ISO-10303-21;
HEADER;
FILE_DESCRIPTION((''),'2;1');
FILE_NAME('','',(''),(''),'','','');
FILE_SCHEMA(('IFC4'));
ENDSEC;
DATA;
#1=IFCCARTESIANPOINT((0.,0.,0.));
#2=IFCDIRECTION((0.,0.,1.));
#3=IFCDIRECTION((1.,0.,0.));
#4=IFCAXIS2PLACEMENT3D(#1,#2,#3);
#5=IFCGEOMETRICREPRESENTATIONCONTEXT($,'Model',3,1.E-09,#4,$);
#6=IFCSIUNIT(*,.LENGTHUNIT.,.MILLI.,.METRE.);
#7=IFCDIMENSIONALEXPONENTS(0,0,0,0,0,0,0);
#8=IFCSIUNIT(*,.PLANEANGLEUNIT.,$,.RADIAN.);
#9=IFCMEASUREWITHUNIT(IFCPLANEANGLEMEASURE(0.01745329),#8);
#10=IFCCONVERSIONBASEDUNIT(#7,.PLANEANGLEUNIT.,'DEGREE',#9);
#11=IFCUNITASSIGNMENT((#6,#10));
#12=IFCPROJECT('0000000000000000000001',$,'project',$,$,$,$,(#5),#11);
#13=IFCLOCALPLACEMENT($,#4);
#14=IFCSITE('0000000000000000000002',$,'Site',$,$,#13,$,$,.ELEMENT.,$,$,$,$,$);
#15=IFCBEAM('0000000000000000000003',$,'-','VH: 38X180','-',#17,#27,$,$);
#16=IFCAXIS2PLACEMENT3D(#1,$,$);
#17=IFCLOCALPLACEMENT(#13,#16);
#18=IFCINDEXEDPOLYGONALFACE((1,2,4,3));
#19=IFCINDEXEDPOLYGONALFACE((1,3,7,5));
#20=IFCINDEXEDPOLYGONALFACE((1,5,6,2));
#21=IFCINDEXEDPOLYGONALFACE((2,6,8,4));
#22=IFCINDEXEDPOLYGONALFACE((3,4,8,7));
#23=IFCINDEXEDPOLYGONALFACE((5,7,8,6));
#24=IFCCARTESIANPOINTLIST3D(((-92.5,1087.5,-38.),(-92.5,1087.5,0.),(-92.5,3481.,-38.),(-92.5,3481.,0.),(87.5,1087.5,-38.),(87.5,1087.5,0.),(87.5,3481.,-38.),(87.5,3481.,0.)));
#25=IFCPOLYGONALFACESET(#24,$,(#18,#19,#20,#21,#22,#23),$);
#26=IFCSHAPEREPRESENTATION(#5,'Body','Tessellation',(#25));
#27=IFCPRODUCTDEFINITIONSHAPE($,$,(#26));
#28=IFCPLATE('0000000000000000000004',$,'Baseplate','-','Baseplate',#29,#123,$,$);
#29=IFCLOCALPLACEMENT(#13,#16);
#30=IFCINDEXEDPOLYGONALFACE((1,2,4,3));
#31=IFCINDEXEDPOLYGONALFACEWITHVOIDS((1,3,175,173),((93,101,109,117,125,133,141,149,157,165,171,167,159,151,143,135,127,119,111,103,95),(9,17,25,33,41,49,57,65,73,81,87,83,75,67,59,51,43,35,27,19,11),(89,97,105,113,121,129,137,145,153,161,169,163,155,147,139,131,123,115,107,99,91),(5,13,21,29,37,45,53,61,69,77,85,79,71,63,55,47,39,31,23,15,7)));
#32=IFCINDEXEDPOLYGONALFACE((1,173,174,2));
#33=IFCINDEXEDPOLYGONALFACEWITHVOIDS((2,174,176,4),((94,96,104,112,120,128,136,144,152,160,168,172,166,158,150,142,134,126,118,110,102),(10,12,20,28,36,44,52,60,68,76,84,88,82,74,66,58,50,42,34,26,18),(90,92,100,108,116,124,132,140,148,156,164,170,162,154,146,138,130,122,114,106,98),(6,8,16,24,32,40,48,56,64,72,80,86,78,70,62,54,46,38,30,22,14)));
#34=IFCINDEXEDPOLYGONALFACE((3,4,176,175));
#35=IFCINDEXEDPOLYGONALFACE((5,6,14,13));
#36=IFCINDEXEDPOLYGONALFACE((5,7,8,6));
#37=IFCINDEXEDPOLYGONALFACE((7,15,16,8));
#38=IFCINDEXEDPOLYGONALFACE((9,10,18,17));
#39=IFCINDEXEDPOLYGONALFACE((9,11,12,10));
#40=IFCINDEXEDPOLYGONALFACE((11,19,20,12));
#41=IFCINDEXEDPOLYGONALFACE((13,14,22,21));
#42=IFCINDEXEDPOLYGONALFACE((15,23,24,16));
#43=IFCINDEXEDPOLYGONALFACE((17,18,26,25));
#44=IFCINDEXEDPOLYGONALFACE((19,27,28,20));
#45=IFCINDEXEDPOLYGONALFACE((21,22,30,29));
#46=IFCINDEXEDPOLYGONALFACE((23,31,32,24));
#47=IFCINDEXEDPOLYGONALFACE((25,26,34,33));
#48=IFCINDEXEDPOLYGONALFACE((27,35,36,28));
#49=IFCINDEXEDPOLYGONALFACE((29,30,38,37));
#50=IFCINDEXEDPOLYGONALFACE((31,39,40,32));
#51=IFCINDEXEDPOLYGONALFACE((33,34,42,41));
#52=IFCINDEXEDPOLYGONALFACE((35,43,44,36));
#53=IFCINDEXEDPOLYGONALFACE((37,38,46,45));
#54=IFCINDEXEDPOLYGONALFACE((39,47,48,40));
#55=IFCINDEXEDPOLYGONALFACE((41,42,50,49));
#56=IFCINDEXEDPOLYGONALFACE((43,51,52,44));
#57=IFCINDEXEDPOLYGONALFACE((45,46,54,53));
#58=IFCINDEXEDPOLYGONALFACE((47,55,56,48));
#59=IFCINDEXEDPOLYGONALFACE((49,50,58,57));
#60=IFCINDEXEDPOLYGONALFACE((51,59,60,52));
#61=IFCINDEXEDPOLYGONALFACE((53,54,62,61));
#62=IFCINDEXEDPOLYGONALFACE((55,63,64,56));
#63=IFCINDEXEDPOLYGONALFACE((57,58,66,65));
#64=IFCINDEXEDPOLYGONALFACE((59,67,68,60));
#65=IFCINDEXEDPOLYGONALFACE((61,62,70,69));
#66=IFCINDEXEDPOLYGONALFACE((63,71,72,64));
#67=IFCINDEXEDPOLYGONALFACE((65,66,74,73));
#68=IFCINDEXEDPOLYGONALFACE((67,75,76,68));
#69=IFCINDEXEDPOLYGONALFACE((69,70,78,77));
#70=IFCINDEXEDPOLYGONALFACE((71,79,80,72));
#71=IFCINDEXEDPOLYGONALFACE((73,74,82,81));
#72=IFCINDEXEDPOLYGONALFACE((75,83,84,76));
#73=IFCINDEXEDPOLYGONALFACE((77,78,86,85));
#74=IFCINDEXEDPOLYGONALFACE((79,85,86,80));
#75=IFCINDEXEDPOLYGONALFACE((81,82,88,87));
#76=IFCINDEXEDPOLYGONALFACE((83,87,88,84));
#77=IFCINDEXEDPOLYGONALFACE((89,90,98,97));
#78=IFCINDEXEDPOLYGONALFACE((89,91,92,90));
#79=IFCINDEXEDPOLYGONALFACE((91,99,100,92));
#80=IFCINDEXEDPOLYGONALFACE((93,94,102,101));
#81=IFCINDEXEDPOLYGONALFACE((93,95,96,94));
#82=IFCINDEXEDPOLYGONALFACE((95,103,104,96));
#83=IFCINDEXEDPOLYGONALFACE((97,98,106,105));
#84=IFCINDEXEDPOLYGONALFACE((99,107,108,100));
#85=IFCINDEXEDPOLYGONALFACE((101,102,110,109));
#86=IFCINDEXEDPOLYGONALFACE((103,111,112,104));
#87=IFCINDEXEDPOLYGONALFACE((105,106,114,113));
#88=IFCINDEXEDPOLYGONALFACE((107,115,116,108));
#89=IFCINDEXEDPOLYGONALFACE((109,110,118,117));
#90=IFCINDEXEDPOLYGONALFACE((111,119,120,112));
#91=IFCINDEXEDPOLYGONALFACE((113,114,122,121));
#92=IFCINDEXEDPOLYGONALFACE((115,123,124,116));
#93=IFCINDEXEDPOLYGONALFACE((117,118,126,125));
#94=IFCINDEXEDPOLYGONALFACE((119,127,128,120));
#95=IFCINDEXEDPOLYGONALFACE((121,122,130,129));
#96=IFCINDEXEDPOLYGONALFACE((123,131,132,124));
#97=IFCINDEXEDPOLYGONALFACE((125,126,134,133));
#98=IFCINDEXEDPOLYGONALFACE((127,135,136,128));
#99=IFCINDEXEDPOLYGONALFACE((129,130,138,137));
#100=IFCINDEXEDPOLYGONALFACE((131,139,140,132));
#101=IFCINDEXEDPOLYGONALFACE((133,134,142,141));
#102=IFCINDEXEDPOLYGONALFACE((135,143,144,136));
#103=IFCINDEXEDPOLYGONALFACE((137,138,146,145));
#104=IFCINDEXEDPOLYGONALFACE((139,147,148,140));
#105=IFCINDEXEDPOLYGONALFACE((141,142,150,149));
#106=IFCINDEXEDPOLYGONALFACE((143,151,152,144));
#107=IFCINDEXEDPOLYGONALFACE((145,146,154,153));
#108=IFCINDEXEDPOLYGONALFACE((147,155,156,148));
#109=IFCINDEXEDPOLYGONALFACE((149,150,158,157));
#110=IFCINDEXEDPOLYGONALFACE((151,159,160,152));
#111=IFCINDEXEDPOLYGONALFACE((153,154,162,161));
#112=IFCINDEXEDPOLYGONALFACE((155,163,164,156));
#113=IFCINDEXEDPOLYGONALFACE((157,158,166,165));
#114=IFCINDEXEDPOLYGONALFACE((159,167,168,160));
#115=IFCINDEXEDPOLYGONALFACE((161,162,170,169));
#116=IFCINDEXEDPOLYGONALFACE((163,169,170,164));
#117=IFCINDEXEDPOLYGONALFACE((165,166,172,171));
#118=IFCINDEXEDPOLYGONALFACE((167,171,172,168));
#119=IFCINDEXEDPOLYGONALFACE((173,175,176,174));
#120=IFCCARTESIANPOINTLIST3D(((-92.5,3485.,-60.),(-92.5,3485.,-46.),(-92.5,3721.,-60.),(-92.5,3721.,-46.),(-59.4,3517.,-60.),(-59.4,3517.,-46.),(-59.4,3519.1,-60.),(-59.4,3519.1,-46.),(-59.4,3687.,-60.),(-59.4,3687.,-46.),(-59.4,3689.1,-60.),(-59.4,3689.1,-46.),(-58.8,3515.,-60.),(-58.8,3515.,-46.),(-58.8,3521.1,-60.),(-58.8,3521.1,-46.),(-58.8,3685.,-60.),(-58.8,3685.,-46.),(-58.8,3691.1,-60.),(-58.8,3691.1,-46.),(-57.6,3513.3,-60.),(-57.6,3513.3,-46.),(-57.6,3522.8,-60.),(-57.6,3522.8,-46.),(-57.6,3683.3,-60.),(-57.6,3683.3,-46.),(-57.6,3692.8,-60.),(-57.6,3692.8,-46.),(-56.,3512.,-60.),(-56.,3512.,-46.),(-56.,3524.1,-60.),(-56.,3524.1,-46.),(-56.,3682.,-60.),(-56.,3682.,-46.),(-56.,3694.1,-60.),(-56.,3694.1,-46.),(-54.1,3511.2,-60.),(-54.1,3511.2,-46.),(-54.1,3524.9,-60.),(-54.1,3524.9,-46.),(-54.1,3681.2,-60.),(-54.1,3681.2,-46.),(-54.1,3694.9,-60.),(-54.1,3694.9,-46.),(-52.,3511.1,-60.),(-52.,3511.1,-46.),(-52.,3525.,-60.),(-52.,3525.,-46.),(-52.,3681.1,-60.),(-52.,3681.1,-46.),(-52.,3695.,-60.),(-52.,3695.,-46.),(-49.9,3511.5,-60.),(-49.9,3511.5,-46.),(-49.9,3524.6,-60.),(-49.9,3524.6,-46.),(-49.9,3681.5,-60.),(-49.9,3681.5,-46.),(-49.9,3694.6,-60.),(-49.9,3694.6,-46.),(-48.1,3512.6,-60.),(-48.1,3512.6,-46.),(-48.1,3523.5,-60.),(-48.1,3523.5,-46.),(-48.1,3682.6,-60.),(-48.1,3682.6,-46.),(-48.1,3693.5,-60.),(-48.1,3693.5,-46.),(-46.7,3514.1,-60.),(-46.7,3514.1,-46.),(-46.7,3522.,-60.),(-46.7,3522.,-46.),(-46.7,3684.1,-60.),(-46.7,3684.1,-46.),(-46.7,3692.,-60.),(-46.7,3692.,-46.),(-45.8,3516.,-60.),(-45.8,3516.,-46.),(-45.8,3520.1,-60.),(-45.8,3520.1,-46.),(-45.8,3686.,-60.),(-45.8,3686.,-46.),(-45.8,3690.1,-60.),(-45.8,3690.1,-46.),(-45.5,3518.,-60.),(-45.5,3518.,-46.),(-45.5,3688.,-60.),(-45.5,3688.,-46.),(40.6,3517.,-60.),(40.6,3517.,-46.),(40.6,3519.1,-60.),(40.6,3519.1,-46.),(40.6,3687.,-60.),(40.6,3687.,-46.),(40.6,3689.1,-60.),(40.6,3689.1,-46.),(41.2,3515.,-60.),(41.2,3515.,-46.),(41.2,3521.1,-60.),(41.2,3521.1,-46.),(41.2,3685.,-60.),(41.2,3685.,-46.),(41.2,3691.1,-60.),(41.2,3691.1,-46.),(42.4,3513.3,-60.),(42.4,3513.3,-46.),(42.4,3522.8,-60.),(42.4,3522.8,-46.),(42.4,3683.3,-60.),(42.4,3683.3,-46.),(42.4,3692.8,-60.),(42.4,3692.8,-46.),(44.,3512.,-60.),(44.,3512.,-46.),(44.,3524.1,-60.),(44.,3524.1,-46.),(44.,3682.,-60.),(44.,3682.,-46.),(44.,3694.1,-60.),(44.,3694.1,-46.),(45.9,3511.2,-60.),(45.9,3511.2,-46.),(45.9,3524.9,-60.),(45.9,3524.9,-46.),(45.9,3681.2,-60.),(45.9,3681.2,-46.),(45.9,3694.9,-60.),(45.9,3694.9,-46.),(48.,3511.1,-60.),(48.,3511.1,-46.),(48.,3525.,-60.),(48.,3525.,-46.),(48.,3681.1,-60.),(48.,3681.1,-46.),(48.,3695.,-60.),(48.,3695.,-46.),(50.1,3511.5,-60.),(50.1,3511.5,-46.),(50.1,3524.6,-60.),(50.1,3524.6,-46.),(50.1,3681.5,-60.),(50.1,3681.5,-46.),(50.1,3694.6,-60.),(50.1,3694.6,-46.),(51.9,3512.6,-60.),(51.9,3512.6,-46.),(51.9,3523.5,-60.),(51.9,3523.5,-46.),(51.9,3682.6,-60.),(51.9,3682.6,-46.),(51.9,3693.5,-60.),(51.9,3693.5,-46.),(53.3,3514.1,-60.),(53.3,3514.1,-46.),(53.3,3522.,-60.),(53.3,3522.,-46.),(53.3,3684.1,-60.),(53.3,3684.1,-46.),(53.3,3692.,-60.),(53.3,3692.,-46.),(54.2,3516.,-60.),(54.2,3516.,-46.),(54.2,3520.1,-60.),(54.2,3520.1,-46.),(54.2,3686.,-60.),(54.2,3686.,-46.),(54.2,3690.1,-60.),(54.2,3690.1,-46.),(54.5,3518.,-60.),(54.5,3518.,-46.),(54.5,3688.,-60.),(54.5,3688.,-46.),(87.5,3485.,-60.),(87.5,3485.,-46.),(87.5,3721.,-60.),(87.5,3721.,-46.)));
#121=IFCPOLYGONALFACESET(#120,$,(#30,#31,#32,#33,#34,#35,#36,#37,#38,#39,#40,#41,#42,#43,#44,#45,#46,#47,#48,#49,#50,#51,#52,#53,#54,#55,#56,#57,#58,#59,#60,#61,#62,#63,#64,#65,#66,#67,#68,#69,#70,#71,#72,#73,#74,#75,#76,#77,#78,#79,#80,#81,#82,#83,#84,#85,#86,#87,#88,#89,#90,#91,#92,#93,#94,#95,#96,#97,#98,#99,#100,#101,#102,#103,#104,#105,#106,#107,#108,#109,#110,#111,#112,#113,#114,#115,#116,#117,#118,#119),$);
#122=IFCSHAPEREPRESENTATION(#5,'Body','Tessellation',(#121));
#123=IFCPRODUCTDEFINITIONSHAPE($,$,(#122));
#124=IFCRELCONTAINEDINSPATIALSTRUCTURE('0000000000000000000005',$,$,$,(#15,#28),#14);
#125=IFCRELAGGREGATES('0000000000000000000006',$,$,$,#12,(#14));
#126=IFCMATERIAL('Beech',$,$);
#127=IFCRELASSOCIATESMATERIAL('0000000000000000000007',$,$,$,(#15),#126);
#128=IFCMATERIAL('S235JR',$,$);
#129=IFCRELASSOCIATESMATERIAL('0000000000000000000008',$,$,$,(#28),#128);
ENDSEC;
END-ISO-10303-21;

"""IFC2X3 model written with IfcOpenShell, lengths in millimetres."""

from ifc_helpers import new_model, entity, si_unit, converted_unit, frame, frame_2d, origin, origin_with_axes, origin_2d, place, context, project, spatial, polyline, rectangle, circle, outline, extrude, material, element, save


model = new_model("IFC2X3")

# Units and contexts
model_context = context("Model", 3, precision=1e-09, world=origin_with_axes())
ifc_project = project(units=[si_unit("LENGTHUNIT", "METRE", prefix="MILLI"), converted_unit("PLANEANGLEUNIT", "DEGREE", entity("IfcPlaneAngleMeasure", 0.01745329), si_unit("PLANEANGLEUNIT", "RADIAN"), dimensions=[0, 0, 0, 0, 0, 0, 0])], contexts=[model_context])

# Site
site_placement = place(None, origin_with_axes())
site = spatial("IfcSite", under=ifc_project, at=site_placement, Name="Site", CompositionType="ELEMENT")

# Shared definitions
ifc_material_1 = material(Name="Beech")

# Beam
for number, where, z_axis, x_axis, name in (
    (1, (-2.5, 3481.0, -19.0), (0.0, -1.0, 0.0), (0.0, 0.0, 1.0), "-"),
):
    element("IfcBeam", number, at=place(None, frame(where, z_axis=z_axis, x_axis=x_axis)), inside=site, material=ifc_material_1, Name=name, Description="VH: 38X180", ObjectType="-", context=model_context, shape_type="SweptSolid", body=[
        extrude(rectangle(XDim=38.0, YDim=180.0, at=origin_2d()), origin(), (0.0, 0.0, 1.0), 2393.5),
    ])

# Plate, openings
ifc_material_2 = material(Name="S235JR")
plate_placement = place(None, frame((-92.5, 3721.0, -46.0), z_axis=(0.0, 0.0, -1.0), x_axis=(1.0, 0.0, 0.0)))
plate = element("IfcPlate", 2, at=plate_placement, inside=site, material=ifc_material_2, Name="Baseplate", Description="-", ObjectType="Baseplate", context=model_context, shape_type="SweptSolid", body=[
    extrude(outline(polyline([(0.0, 0.0), (180.0, 0.0), (180.0, 236.0), (0.0, 236.0), (0.0, 0.0)])), origin_with_axes(), (0.0, 0.0, 1.0), 14.0),
])
opening_1_placement = place(plate_placement, frame((90.0, 118.0, 14.5), z_axis=(0.0, 0.0, -1.0), x_axis=(1.0, 0.0, 0.0)))
element("IfcOpeningElement", 3, at=opening_1_placement, cuts=plate, ObjectType="Opening", context=model_context, shape_type="SweptSolid", body=[
    extrude(circle(Radius=7.0, at=frame_2d((50.0, 85.0), x_axis=(1.0, 0.0))), origin(), (0.0, 0.0, 1.0), 15.0),
])
opening_2_placement = place(plate_placement, frame((90.0, 118.0, 14.5), z_axis=(0.0, 0.0, -1.0), x_axis=(1.0, 0.0, 0.0)))
element("IfcOpeningElement", 4, at=opening_2_placement, cuts=plate, ObjectType="Opening", context=model_context, shape_type="SweptSolid", body=[
    extrude(circle(Radius=7.0, at=frame_2d((-50.0, 85.0), x_axis=(1.0, 0.0))), origin(), (0.0, 0.0, 1.0), 15.0),
])
opening_3_placement = place(plate_placement, frame((90.0, 118.0, 14.5), z_axis=(0.0, 0.0, -1.0), x_axis=(1.0, 0.0, 0.0)))
element("IfcOpeningElement", 5, at=opening_3_placement, cuts=plate, ObjectType="Opening", context=model_context, shape_type="SweptSolid", body=[
    extrude(circle(Radius=7.0, at=frame_2d((50.0, -85.0), x_axis=(1.0, 0.0))), origin(), (0.0, 0.0, 1.0), 15.0),
])
opening_4_placement = place(plate_placement, frame((90.0, 118.0, 14.5), z_axis=(0.0, 0.0, -1.0), x_axis=(1.0, 0.0, 0.0)))
element("IfcOpeningElement", 6, at=opening_4_placement, cuts=plate, ObjectType="Opening", context=model_context, shape_type="SweptSolid", body=[
    extrude(circle(Radius=7.0, at=frame_2d((-50.0, -85.0), x_axis=(1.0, 0.0))), origin(), (0.0, 0.0, 1.0), 15.0),
])

save(model, "model.ifc")
